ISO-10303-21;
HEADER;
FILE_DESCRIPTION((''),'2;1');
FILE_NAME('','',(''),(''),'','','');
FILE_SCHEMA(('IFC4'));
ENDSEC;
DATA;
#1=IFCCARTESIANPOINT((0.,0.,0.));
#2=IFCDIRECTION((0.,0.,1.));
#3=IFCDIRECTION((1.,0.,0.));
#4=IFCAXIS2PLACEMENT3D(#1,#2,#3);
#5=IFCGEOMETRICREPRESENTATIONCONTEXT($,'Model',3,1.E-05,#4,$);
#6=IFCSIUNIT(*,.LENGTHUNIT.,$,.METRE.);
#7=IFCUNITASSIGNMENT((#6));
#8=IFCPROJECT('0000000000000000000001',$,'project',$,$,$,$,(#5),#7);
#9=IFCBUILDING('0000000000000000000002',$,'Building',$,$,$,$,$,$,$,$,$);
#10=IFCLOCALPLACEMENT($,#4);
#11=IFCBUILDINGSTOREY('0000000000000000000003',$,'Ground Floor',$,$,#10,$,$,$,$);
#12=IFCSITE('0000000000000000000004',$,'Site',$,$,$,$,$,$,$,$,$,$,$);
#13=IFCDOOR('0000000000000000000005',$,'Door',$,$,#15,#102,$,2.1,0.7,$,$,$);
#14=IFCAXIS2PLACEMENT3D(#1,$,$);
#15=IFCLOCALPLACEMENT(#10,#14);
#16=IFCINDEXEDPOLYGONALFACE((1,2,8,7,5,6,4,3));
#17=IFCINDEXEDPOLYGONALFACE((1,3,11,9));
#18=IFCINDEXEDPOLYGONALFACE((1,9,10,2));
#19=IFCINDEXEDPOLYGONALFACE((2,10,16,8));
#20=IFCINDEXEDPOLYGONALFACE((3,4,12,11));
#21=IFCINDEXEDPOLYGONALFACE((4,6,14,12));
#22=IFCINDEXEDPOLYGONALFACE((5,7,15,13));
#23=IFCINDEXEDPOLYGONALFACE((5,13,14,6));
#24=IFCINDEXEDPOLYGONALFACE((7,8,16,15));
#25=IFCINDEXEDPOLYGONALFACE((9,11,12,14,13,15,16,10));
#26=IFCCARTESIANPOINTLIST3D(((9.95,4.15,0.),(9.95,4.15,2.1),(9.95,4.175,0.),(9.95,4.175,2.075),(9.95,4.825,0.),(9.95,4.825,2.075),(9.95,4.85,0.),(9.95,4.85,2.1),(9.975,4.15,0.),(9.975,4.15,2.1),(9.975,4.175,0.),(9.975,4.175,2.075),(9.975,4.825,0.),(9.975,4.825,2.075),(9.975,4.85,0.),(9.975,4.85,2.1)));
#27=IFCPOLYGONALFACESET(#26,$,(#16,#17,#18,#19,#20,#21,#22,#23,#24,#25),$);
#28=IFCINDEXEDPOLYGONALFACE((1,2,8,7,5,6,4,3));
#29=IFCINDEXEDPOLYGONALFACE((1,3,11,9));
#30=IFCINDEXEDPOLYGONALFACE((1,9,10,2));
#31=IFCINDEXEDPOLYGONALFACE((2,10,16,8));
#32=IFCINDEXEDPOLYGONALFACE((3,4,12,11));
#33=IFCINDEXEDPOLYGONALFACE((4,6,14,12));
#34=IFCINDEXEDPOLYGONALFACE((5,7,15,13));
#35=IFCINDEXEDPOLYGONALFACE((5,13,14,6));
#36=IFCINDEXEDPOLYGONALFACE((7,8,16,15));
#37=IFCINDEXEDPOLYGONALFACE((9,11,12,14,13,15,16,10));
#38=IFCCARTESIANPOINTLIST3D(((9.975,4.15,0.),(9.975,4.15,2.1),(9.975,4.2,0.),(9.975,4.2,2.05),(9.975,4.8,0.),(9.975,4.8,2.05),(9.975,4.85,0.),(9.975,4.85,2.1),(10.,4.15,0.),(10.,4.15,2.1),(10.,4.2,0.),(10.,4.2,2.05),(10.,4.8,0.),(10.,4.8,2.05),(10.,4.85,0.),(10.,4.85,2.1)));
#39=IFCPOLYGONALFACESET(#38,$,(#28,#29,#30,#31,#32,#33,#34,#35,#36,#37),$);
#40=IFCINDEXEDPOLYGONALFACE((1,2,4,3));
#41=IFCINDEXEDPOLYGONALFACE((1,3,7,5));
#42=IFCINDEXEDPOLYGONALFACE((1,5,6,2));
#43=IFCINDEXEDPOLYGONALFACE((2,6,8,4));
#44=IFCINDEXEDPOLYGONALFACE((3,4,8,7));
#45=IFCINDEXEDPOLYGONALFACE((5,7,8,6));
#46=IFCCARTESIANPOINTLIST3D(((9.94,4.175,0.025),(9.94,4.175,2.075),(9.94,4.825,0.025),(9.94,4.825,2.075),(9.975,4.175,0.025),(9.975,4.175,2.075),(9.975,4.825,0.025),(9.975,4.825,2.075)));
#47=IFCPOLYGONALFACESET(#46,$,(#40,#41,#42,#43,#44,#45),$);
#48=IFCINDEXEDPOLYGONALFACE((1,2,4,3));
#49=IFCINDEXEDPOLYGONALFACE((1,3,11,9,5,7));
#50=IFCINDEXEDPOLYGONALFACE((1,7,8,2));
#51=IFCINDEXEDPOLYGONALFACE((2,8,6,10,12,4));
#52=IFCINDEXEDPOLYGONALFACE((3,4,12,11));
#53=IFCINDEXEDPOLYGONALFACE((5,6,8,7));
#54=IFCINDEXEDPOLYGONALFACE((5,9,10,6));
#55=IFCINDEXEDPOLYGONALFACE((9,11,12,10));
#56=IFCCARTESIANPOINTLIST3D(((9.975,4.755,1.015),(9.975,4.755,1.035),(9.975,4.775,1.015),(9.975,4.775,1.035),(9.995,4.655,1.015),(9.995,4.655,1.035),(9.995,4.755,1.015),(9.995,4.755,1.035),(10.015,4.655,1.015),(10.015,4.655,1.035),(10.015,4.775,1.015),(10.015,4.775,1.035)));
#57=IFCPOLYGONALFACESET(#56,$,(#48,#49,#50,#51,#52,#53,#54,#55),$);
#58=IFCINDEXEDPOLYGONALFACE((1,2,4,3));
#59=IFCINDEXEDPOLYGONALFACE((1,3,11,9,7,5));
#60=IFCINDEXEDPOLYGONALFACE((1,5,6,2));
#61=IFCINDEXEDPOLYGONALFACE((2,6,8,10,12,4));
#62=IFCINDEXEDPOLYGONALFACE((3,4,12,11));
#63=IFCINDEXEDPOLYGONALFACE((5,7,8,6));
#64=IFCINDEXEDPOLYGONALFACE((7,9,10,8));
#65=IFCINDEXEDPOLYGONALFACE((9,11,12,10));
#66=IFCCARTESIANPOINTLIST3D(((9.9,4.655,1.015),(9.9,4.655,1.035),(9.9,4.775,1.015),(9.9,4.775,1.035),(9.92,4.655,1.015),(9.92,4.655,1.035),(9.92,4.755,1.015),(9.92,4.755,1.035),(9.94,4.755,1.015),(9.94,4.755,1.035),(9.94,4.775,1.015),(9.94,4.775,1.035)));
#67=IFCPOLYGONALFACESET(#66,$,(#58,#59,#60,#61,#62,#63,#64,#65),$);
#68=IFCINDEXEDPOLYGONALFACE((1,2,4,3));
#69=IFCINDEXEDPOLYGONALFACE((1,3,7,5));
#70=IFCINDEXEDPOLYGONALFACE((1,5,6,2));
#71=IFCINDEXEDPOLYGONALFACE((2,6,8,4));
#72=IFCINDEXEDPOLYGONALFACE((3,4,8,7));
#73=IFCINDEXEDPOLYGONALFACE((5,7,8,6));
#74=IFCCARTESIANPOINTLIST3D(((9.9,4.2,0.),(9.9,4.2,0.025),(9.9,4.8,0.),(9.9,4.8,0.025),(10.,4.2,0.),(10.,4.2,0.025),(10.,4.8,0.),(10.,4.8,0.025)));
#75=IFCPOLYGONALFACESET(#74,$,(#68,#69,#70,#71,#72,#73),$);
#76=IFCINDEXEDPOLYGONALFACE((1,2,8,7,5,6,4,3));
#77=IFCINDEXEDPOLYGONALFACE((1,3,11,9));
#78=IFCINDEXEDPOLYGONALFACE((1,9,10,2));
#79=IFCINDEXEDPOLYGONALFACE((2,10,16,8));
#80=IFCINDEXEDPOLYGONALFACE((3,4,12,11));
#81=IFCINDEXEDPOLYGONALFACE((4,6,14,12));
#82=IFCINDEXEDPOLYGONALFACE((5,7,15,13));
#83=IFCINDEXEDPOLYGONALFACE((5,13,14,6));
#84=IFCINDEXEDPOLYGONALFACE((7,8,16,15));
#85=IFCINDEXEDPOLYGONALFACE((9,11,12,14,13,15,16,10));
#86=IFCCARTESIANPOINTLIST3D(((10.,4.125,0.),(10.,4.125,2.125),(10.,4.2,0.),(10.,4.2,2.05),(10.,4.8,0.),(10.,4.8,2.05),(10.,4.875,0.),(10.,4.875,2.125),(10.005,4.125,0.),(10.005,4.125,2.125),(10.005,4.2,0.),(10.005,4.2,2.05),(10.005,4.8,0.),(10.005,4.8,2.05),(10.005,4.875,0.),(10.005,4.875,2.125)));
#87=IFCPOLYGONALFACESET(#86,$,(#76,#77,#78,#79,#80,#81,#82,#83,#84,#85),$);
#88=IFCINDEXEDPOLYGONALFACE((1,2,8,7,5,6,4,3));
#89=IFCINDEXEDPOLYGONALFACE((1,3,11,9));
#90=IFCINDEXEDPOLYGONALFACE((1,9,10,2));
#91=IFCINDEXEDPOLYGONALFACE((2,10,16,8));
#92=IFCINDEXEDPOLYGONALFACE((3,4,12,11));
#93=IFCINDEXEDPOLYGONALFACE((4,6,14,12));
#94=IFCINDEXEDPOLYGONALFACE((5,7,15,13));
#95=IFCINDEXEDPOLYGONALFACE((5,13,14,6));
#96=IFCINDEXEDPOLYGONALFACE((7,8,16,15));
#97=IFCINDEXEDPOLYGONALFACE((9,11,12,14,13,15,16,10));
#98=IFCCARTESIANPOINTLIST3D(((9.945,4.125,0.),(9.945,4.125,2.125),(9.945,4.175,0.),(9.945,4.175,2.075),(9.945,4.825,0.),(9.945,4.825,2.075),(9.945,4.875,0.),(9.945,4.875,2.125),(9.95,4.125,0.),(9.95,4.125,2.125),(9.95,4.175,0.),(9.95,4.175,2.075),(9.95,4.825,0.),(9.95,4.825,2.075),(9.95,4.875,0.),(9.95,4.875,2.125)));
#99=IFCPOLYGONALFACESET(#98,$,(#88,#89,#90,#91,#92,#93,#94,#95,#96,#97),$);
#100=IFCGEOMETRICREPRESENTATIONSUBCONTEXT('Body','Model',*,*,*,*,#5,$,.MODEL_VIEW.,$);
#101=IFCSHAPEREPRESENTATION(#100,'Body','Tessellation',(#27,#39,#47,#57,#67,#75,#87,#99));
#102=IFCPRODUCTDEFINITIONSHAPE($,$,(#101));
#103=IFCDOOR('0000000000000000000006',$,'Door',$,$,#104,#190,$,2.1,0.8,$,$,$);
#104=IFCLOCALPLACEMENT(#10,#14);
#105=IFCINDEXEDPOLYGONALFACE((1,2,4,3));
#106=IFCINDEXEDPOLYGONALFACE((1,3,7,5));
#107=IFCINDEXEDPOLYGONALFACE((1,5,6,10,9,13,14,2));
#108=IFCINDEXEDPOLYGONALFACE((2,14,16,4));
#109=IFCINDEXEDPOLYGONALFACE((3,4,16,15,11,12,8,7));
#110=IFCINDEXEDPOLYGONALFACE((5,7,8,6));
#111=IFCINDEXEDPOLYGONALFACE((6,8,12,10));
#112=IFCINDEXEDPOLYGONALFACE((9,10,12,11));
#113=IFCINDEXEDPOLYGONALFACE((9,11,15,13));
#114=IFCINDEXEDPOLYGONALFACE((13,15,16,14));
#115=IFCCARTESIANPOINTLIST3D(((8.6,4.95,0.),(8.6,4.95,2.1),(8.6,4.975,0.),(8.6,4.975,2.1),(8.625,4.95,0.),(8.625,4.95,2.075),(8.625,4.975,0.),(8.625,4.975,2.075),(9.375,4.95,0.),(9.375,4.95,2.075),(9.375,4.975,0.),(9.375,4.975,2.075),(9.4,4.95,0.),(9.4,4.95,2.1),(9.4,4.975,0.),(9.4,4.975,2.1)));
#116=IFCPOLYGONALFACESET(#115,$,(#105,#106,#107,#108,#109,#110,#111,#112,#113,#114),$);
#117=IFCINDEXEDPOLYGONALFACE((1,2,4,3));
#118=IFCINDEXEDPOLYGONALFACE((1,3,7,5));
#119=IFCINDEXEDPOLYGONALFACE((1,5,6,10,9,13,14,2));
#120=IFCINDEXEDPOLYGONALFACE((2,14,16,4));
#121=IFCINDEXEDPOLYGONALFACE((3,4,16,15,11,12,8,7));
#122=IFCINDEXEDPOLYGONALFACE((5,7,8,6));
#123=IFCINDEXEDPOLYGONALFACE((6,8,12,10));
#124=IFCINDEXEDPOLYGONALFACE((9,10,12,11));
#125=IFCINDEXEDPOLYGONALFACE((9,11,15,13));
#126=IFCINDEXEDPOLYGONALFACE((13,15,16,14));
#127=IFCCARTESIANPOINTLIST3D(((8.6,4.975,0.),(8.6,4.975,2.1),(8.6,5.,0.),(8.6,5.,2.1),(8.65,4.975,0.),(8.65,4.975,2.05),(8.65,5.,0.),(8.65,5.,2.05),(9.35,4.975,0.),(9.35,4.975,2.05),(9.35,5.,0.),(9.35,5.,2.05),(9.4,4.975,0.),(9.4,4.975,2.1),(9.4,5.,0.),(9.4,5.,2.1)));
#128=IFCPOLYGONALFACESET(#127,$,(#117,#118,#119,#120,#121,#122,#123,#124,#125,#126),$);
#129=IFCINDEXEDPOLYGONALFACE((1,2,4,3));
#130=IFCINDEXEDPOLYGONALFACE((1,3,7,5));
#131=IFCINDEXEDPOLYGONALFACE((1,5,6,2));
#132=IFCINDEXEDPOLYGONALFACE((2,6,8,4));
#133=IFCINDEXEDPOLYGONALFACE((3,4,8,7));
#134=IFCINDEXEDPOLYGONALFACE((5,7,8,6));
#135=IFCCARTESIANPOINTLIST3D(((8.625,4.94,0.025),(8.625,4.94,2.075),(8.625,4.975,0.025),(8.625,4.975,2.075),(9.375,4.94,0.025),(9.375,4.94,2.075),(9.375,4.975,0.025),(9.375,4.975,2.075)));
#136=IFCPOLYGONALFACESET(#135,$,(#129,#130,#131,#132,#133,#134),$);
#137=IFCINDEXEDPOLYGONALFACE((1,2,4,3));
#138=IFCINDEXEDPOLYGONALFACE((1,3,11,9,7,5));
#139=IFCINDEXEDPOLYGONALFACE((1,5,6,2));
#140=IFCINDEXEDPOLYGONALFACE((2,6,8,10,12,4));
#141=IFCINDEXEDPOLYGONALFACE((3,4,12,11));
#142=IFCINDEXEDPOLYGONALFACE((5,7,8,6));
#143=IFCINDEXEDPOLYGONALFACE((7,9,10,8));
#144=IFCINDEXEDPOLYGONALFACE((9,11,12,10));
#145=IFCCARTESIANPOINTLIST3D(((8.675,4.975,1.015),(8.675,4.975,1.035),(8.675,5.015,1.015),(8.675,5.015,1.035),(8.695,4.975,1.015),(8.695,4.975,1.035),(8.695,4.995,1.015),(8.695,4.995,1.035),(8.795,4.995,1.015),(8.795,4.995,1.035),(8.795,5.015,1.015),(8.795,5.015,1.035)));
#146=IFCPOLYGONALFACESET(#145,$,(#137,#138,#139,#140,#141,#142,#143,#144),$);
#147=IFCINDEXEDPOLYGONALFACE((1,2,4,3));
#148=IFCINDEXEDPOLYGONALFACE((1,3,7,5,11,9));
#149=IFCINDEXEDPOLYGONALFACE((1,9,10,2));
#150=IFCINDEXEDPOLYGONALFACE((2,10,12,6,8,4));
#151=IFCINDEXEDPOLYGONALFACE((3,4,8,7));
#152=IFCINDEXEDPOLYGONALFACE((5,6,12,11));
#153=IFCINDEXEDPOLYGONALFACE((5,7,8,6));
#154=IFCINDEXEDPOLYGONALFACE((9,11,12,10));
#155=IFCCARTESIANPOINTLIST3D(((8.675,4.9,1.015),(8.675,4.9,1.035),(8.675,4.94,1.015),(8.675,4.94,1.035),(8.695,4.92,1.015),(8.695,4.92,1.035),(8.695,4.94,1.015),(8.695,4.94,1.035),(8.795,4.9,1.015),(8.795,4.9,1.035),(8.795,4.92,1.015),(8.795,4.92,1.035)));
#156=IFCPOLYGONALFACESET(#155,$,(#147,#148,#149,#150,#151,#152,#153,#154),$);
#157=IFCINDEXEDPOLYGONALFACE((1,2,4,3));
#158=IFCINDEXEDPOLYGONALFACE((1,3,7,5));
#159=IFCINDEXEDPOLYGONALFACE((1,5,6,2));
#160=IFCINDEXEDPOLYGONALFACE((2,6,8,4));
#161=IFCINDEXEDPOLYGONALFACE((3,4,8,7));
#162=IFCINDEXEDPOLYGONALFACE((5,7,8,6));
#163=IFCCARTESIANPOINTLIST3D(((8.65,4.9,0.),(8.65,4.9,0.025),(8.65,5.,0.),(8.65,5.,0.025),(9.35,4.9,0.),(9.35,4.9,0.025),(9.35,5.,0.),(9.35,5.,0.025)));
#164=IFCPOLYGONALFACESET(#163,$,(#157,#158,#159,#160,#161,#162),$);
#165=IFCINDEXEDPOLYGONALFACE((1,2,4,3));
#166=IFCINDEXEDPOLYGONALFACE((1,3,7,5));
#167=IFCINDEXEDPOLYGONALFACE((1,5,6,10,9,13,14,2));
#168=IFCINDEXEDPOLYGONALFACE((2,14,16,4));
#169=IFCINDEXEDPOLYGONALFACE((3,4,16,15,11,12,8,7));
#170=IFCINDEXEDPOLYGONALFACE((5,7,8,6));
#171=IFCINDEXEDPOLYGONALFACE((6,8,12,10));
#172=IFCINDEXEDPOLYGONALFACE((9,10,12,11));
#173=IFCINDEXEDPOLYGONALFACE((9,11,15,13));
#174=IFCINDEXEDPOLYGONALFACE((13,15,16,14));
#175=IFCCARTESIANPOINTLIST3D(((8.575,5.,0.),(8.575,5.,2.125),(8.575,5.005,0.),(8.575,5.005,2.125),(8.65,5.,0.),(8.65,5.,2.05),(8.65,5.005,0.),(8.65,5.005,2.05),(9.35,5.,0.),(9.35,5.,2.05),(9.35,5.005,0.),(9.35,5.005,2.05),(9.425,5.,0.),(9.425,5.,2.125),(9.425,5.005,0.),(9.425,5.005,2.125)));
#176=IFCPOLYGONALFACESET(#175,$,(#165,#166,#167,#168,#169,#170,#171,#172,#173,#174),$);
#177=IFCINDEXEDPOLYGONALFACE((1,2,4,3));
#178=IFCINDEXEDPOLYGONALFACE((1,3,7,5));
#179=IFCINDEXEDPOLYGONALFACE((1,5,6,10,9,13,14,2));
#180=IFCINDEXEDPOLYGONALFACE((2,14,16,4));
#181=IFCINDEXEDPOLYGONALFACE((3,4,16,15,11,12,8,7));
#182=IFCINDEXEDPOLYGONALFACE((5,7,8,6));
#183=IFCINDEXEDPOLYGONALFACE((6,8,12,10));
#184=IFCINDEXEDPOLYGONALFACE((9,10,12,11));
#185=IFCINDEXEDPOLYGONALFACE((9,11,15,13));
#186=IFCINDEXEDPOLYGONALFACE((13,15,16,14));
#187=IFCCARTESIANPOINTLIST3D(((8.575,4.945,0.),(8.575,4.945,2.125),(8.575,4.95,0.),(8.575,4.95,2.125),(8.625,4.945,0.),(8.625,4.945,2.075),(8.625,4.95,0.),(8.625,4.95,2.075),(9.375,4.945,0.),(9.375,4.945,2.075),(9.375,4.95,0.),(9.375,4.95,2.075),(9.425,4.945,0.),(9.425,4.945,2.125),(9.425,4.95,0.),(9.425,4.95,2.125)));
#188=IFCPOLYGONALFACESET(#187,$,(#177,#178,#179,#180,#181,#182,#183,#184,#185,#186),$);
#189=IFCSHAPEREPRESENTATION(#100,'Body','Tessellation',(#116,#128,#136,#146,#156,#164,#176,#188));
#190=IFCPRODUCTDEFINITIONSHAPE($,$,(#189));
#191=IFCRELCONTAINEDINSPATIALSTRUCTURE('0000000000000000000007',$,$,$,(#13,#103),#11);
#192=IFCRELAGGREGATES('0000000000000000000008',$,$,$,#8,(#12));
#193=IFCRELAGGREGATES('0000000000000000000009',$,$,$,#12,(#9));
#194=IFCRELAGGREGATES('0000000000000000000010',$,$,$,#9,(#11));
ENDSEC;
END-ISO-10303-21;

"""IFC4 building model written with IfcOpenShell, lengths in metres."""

from ifc_helpers import new_model, si_unit, frame, origin_with_axes, place, context, subcontext, project, spatial, line, indexed_curve, outline, extrude, element, save


model = new_model("IFC4")

# Units and contexts
model_context = context("Model", 3, precision=1e-05, world=origin_with_axes())
body_context = subcontext(model_context, "Body", "Model", "MODEL_VIEW")
ifc_project = project(units=[si_unit("LENGTHUNIT", "METRE")], contexts=[model_context])

# Site, building, storey
site = spatial("IfcSite", under=ifc_project, Name="Site")
building = spatial("IfcBuilding", under=site, Name="Building")
storey_placement = place(None, origin_with_axes())
storey = spatial("IfcBuildingStorey", under=building, at=storey_placement, Name="Ground Floor")

# Doors
door_1_placement = place(storey_placement, frame((10.0, 4.15, 0.0), z_axis=(0.0, 0.0, 1.0), x_axis=(0.0, 1.0, 0.0)))
element("IfcDoor", 1, at=door_1_placement, inside=storey, Name="Door", OverallHeight=2.1, OverallWidth=0.7, context=body_context, shape_type="SweptSolid", body=[
    extrude(outline(indexed_curve([(0.0, 0.0), (0.0, 2.1), (0.7, 2.1), (0.7, 0.0), (0.675, 0.0), (0.675, 2.075), (0.025, 2.075), (0.025, 0.0)], segments=[line(1, 2, 3, 4, 5, 6, 7, 8, 1)])), frame((0.0, 0.025, 0.0), z_axis=(0.0, -1.0, 0.0), x_axis=(1.0, 0.0, 0.0)), (0.0, 0.0, -1.0), 0.025),
    extrude(outline(indexed_curve([(0.0, 0.0), (0.0, 2.1), (0.7, 2.1), (0.7, 0.0), (0.65, 0.0), (0.65, 2.05), (0.05, 2.05), (0.05, 0.0)], segments=[line(1, 2, 3, 4, 5, 6, 7, 8, 1)])), frame((0.0, 0.0, 0.0), z_axis=(0.0, -1.0, 0.0), x_axis=(1.0, 0.0, 0.0)), (0.0, 0.0, -1.0), 0.025),
    extrude(outline(indexed_curve([(0.0, 0.0), (0.65, 0.0), (0.65, 0.035), (0.0, 0.035)], segments=[line(1, 2, 3, 4, 1)])), frame((0.025, 0.025, 0.025), z_axis=(0.0, 0.0, 1.0), x_axis=(1.0, 0.0, 0.0)), (0.0, 0.0, 1.0), 2.05),
    extrude(outline(indexed_curve([(0.0, 0.0), (0.0, -0.04), (-0.12, -0.04), (-0.12, -0.02), (-0.02, -0.02), (-0.02, 0.0)], segments=[line(1, 2, 3, 4, 5, 6, 1)])), frame((0.625, 0.025, 1.015), z_axis=(0.0, 0.0, 1.0), x_axis=(1.0, 0.0, 0.0)), (0.0, 0.0, 1.0), 0.02),
    extrude(outline(indexed_curve([(0.0, 0.0), (0.0, 0.04), (-0.12, 0.04), (-0.12, 0.02), (-0.02, 0.02), (-0.02, 0.0)], segments=[line(1, 2, 3, 4, 5, 6, 1)])), frame((0.625, 0.06, 1.015), z_axis=(0.0, 0.0, 1.0), x_axis=(1.0, 0.0, 0.0)), (0.0, 0.0, 1.0), 0.02),
    extrude(outline(indexed_curve([(0.0, 0.0), (0.6, 0.0), (0.6, 0.1), (0.0, 0.1)], segments=[line(1, 2, 3, 4, 1)])), frame((0.05, 0.0, 0.0), z_axis=(0.0, 0.0, 1.0), x_axis=(1.0, 0.0, 0.0)), (0.0, 0.0, 1.0), 0.025),
    extrude(outline(indexed_curve([(0.0, 0.0), (0.0, 2.125), (0.75, 2.125), (0.75, 0.0), (0.675, 0.0), (0.675, 2.05), (0.075, 2.05), (0.075, 0.0)], segments=[line(1, 2, 3, 4, 5, 6, 7, 8, 1)])), frame((-0.025, -0.005, 0.0), z_axis=(0.0, -1.0, 0.0), x_axis=(1.0, 0.0, 0.0)), (0.0, 0.0, -1.0), 0.005),
    extrude(outline(indexed_curve([(0.0, 0.0), (0.0, 2.125), (0.75, 2.125), (0.75, 0.0), (0.7, 0.0), (0.7, 2.075), (0.05, 2.075), (0.05, 0.0)], segments=[line(1, 2, 3, 4, 5, 6, 7, 8, 1)])), frame((-0.025, 0.05, 0.0), z_axis=(0.0, -1.0, 0.0), x_axis=(1.0, 0.0, 0.0)), (0.0, 0.0, -1.0), 0.005),
])
door_2_placement = place(storey_placement, frame((9.4, 5.0, 0.0), z_axis=(0.0, 0.0, 1.0), x_axis=(-1.0, 0.0, 0.0)))
element("IfcDoor", 2, at=door_2_placement, inside=storey, Name="Door", OverallHeight=2.1, OverallWidth=0.8, context=body_context, shape_type="SweptSolid", body=[
    extrude(outline(indexed_curve([(0.0, 0.0), (0.0, 2.1), (0.8, 2.1), (0.8, 0.0), (0.775, 0.0), (0.775, 2.075), (0.025, 2.075), (0.025, 0.0)], segments=[line(1, 2, 3, 4, 5, 6, 7, 8, 1)])), frame((0.0, 0.025, 0.0), z_axis=(0.0, -1.0, 0.0), x_axis=(1.0, 0.0, 0.0)), (0.0, 0.0, -1.0), 0.025),
    extrude(outline(indexed_curve([(0.0, 0.0), (0.0, 2.1), (0.8, 2.1), (0.8, 0.0), (0.75, 0.0), (0.75, 2.05), (0.05, 2.05), (0.05, 0.0)], segments=[line(1, 2, 3, 4, 5, 6, 7, 8, 1)])), frame((0.0, 0.0, 0.0), z_axis=(0.0, -1.0, 0.0), x_axis=(1.0, 0.0, 0.0)), (0.0, 0.0, -1.0), 0.025),
    extrude(outline(indexed_curve([(0.0, 0.0), (0.75, 0.0), (0.75, 0.035), (0.0, 0.035)], segments=[line(1, 2, 3, 4, 1)])), frame((0.025, 0.025, 0.025), z_axis=(0.0, 0.0, 1.0), x_axis=(1.0, 0.0, 0.0)), (0.0, 0.0, 1.0), 2.05),
    extrude(outline(indexed_curve([(0.0, 0.0), (0.0, -0.04), (-0.12, -0.04), (-0.12, -0.02), (-0.02, -0.02), (-0.02, 0.0)], segments=[line(1, 2, 3, 4, 5, 6, 1)])), frame((0.725, 0.025, 1.015), z_axis=(0.0, 0.0, 1.0), x_axis=(1.0, 0.0, 0.0)), (0.0, 0.0, 1.0), 0.02),
    extrude(outline(indexed_curve([(0.0, 0.0), (0.0, 0.04), (-0.12, 0.04), (-0.12, 0.02), (-0.02, 0.02), (-0.02, 0.0)], segments=[line(1, 2, 3, 4, 5, 6, 1)])), frame((0.725, 0.06, 1.015), z_axis=(0.0, 0.0, 1.0), x_axis=(1.0, 0.0, 0.0)), (0.0, 0.0, 1.0), 0.02),
    extrude(outline(indexed_curve([(0.0, 0.0), (0.7, 0.0), (0.7, 0.1), (0.0, 0.1)], segments=[line(1, 2, 3, 4, 1)])), frame((0.05, 0.0, 0.0), z_axis=(0.0, 0.0, 1.0), x_axis=(1.0, 0.0, 0.0)), (0.0, 0.0, 1.0), 0.025),
    extrude(outline(indexed_curve([(0.0, 0.0), (0.0, 2.125), (0.85, 2.125), (0.85, 0.0), (0.775, 0.0), (0.775, 2.05), (0.075, 2.05), (0.075, 0.0)], segments=[line(1, 2, 3, 4, 5, 6, 7, 8, 1)])), frame((-0.025, -0.005, 0.0), z_axis=(0.0, -1.0, 0.0), x_axis=(1.0, 0.0, 0.0)), (0.0, 0.0, -1.0), 0.005),
    extrude(outline(indexed_curve([(0.0, 0.0), (0.0, 2.125), (0.85, 2.125), (0.85, 0.0), (0.8, 0.0), (0.8, 2.075), (0.05, 2.075), (0.05, 0.0)], segments=[line(1, 2, 3, 4, 5, 6, 7, 8, 1)])), frame((-0.025, 0.05, 0.0), z_axis=(0.0, -1.0, 0.0), x_axis=(1.0, 0.0, 0.0)), (0.0, 0.0, -1.0), 0.005),
])

save(model, "model.ifc")
